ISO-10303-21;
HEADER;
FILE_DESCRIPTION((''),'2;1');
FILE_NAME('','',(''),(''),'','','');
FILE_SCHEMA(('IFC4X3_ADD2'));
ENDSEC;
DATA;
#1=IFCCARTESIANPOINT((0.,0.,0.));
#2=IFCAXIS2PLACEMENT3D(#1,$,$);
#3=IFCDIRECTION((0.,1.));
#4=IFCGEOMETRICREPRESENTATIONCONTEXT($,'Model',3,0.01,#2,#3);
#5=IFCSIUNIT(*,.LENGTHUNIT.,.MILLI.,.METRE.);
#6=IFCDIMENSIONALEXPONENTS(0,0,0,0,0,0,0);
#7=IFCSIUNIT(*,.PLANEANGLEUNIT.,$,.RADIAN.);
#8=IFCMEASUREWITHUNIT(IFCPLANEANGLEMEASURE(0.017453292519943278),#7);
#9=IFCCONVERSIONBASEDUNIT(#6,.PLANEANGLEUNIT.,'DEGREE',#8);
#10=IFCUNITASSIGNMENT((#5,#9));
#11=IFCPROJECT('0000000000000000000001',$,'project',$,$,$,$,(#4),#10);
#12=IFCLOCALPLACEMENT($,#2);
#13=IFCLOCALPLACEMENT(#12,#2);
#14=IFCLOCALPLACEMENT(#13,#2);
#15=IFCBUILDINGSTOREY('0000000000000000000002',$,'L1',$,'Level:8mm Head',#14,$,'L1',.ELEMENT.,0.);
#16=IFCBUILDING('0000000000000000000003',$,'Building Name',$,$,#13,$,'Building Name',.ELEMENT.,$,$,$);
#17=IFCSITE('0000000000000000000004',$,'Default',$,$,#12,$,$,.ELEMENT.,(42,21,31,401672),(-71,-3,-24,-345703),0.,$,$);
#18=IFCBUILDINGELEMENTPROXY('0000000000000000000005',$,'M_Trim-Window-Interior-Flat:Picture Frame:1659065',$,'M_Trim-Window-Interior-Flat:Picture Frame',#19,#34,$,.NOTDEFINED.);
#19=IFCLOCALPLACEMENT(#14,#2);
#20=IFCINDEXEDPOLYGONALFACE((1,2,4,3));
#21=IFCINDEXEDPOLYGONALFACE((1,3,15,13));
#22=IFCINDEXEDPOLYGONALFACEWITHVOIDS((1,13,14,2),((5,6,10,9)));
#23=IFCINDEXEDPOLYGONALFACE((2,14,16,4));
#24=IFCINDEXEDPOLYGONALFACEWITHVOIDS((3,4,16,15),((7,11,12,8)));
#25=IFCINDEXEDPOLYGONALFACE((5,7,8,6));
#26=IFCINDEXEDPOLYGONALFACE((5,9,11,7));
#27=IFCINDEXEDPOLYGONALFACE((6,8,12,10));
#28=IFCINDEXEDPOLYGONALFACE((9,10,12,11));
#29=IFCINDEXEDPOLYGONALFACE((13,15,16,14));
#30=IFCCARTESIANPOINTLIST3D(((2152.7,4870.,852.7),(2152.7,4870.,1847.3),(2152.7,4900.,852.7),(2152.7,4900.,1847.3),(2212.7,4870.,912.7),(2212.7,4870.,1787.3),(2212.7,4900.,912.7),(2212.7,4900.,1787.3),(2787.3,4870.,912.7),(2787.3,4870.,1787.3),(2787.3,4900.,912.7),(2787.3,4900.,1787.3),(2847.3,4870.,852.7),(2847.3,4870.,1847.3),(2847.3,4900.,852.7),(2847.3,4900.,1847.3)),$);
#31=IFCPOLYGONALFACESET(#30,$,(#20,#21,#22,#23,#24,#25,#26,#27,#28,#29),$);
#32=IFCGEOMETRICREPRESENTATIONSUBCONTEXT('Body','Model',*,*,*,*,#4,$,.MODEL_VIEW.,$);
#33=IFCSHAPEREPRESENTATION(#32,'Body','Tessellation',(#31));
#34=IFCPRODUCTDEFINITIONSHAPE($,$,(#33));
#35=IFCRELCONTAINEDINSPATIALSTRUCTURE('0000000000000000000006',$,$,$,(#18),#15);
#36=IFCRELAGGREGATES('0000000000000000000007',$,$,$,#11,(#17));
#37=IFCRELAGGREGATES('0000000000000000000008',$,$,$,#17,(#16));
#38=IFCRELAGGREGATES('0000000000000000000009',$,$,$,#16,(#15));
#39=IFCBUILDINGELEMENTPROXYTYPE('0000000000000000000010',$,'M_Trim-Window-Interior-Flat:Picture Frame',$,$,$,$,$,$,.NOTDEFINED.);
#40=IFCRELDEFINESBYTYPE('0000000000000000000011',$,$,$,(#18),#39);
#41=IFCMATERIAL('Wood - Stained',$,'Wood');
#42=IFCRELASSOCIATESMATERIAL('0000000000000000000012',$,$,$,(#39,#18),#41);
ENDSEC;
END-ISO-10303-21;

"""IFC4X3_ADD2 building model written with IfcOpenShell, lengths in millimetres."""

from ifc_helpers import new_model, entity, si_unit, converted_unit, direction, frame, origin, place, context, subcontext, project, spatial, polyline, outline, extrude, source, transform, mapped, material, type_object, type_shapes, element, save


model = new_model("IFC4X3_ADD2")

# Units and contexts
model_context = context("Model", 3, precision=0.01, world=origin(), true_north=direction((0.0, 1.0)))
body_context = subcontext(model_context, "Body", "Model", "MODEL_VIEW")
ifc_project = project(units=[si_unit("LENGTHUNIT", "METRE", prefix="MILLI"), converted_unit("PLANEANGLEUNIT", "DEGREE", entity("IfcPlaneAngleMeasure", 0.017453292519943278), si_unit("PLANEANGLEUNIT", "RADIAN"), dimensions=[0, 0, 0, 0, 0, 0, 0])], contexts=[model_context])

# Site, building, storey
site_placement = place(None, origin())
site = spatial("IfcSite", under=ifc_project, at=site_placement, Name="Default", CompositionType="ELEMENT", RefLatitude=(42, 21, 31, 401672), RefLongitude=(-71, -3, -24, -345703), RefElevation=0.0)
building_placement = place(site_placement, origin())
building = spatial("IfcBuilding", under=site, at=building_placement, Name="Building Name", LongName="Building Name", CompositionType="ELEMENT")
storey_placement = place(building_placement, origin())
storey = spatial("IfcBuildingStorey", under=building, at=storey_placement, Name="L1", ObjectType="Level:8mm Head", LongName="L1", CompositionType="ELEMENT", Elevation=0.0)

# Building element proxy
ifc_material_1 = material(Name="Wood - Stained", Category="Wood")
building_element_proxy_type_1 = type_object("IfcBuildingElementProxyType", Name="M_Trim-Window-Interior-Flat:Picture Frame", PredefinedType="NOTDEFINED", material=ifc_material_1)
shared_shape_1 = source(origin(), body_context, "Body", "SweptSolid", [
    extrude(outline(polyline([(-347.3, -497.3), (347.3, -497.3), (347.3, 497.3), (-347.3, 497.3), (-347.3, -497.3)]), holes=[polyline([(-287.3, -437.3), (-287.3, 437.3), (287.3, 437.3), (287.3, -437.3), (-287.3, -437.3)])]), frame((0.0, -450.0, 0.0), z_axis=(0.0, 0.0, 1.0), x_axis=(-1.0, 0.0, 0.0)), (0.0, 0.0, 1.0), 30.0),
])
type_shapes(building_element_proxy_type_1, [shared_shape_1])
proxy_1_placement = place(storey_placement, frame((2500.0, 4900.0, 1800.0), z_axis=(0.0, -1.0, 0.0), x_axis=(1.0, 0.0, 0.0)))
element("IfcBuildingElementProxy", 1, at=proxy_1_placement, inside=storey, type_object=building_element_proxy_type_1, material=ifc_material_1, Name="M_Trim-Window-Interior-Flat:Picture Frame:1659065", ObjectType="M_Trim-Window-Interior-Flat:Picture Frame", PredefinedType="NOTDEFINED", context=body_context, shape_type="MappedRepresentation", body=[
    mapped(shared_shape_1, transform((0.0, 0.0, 0.0), scale=1.0)),
])

save(model, "model.ifc")
